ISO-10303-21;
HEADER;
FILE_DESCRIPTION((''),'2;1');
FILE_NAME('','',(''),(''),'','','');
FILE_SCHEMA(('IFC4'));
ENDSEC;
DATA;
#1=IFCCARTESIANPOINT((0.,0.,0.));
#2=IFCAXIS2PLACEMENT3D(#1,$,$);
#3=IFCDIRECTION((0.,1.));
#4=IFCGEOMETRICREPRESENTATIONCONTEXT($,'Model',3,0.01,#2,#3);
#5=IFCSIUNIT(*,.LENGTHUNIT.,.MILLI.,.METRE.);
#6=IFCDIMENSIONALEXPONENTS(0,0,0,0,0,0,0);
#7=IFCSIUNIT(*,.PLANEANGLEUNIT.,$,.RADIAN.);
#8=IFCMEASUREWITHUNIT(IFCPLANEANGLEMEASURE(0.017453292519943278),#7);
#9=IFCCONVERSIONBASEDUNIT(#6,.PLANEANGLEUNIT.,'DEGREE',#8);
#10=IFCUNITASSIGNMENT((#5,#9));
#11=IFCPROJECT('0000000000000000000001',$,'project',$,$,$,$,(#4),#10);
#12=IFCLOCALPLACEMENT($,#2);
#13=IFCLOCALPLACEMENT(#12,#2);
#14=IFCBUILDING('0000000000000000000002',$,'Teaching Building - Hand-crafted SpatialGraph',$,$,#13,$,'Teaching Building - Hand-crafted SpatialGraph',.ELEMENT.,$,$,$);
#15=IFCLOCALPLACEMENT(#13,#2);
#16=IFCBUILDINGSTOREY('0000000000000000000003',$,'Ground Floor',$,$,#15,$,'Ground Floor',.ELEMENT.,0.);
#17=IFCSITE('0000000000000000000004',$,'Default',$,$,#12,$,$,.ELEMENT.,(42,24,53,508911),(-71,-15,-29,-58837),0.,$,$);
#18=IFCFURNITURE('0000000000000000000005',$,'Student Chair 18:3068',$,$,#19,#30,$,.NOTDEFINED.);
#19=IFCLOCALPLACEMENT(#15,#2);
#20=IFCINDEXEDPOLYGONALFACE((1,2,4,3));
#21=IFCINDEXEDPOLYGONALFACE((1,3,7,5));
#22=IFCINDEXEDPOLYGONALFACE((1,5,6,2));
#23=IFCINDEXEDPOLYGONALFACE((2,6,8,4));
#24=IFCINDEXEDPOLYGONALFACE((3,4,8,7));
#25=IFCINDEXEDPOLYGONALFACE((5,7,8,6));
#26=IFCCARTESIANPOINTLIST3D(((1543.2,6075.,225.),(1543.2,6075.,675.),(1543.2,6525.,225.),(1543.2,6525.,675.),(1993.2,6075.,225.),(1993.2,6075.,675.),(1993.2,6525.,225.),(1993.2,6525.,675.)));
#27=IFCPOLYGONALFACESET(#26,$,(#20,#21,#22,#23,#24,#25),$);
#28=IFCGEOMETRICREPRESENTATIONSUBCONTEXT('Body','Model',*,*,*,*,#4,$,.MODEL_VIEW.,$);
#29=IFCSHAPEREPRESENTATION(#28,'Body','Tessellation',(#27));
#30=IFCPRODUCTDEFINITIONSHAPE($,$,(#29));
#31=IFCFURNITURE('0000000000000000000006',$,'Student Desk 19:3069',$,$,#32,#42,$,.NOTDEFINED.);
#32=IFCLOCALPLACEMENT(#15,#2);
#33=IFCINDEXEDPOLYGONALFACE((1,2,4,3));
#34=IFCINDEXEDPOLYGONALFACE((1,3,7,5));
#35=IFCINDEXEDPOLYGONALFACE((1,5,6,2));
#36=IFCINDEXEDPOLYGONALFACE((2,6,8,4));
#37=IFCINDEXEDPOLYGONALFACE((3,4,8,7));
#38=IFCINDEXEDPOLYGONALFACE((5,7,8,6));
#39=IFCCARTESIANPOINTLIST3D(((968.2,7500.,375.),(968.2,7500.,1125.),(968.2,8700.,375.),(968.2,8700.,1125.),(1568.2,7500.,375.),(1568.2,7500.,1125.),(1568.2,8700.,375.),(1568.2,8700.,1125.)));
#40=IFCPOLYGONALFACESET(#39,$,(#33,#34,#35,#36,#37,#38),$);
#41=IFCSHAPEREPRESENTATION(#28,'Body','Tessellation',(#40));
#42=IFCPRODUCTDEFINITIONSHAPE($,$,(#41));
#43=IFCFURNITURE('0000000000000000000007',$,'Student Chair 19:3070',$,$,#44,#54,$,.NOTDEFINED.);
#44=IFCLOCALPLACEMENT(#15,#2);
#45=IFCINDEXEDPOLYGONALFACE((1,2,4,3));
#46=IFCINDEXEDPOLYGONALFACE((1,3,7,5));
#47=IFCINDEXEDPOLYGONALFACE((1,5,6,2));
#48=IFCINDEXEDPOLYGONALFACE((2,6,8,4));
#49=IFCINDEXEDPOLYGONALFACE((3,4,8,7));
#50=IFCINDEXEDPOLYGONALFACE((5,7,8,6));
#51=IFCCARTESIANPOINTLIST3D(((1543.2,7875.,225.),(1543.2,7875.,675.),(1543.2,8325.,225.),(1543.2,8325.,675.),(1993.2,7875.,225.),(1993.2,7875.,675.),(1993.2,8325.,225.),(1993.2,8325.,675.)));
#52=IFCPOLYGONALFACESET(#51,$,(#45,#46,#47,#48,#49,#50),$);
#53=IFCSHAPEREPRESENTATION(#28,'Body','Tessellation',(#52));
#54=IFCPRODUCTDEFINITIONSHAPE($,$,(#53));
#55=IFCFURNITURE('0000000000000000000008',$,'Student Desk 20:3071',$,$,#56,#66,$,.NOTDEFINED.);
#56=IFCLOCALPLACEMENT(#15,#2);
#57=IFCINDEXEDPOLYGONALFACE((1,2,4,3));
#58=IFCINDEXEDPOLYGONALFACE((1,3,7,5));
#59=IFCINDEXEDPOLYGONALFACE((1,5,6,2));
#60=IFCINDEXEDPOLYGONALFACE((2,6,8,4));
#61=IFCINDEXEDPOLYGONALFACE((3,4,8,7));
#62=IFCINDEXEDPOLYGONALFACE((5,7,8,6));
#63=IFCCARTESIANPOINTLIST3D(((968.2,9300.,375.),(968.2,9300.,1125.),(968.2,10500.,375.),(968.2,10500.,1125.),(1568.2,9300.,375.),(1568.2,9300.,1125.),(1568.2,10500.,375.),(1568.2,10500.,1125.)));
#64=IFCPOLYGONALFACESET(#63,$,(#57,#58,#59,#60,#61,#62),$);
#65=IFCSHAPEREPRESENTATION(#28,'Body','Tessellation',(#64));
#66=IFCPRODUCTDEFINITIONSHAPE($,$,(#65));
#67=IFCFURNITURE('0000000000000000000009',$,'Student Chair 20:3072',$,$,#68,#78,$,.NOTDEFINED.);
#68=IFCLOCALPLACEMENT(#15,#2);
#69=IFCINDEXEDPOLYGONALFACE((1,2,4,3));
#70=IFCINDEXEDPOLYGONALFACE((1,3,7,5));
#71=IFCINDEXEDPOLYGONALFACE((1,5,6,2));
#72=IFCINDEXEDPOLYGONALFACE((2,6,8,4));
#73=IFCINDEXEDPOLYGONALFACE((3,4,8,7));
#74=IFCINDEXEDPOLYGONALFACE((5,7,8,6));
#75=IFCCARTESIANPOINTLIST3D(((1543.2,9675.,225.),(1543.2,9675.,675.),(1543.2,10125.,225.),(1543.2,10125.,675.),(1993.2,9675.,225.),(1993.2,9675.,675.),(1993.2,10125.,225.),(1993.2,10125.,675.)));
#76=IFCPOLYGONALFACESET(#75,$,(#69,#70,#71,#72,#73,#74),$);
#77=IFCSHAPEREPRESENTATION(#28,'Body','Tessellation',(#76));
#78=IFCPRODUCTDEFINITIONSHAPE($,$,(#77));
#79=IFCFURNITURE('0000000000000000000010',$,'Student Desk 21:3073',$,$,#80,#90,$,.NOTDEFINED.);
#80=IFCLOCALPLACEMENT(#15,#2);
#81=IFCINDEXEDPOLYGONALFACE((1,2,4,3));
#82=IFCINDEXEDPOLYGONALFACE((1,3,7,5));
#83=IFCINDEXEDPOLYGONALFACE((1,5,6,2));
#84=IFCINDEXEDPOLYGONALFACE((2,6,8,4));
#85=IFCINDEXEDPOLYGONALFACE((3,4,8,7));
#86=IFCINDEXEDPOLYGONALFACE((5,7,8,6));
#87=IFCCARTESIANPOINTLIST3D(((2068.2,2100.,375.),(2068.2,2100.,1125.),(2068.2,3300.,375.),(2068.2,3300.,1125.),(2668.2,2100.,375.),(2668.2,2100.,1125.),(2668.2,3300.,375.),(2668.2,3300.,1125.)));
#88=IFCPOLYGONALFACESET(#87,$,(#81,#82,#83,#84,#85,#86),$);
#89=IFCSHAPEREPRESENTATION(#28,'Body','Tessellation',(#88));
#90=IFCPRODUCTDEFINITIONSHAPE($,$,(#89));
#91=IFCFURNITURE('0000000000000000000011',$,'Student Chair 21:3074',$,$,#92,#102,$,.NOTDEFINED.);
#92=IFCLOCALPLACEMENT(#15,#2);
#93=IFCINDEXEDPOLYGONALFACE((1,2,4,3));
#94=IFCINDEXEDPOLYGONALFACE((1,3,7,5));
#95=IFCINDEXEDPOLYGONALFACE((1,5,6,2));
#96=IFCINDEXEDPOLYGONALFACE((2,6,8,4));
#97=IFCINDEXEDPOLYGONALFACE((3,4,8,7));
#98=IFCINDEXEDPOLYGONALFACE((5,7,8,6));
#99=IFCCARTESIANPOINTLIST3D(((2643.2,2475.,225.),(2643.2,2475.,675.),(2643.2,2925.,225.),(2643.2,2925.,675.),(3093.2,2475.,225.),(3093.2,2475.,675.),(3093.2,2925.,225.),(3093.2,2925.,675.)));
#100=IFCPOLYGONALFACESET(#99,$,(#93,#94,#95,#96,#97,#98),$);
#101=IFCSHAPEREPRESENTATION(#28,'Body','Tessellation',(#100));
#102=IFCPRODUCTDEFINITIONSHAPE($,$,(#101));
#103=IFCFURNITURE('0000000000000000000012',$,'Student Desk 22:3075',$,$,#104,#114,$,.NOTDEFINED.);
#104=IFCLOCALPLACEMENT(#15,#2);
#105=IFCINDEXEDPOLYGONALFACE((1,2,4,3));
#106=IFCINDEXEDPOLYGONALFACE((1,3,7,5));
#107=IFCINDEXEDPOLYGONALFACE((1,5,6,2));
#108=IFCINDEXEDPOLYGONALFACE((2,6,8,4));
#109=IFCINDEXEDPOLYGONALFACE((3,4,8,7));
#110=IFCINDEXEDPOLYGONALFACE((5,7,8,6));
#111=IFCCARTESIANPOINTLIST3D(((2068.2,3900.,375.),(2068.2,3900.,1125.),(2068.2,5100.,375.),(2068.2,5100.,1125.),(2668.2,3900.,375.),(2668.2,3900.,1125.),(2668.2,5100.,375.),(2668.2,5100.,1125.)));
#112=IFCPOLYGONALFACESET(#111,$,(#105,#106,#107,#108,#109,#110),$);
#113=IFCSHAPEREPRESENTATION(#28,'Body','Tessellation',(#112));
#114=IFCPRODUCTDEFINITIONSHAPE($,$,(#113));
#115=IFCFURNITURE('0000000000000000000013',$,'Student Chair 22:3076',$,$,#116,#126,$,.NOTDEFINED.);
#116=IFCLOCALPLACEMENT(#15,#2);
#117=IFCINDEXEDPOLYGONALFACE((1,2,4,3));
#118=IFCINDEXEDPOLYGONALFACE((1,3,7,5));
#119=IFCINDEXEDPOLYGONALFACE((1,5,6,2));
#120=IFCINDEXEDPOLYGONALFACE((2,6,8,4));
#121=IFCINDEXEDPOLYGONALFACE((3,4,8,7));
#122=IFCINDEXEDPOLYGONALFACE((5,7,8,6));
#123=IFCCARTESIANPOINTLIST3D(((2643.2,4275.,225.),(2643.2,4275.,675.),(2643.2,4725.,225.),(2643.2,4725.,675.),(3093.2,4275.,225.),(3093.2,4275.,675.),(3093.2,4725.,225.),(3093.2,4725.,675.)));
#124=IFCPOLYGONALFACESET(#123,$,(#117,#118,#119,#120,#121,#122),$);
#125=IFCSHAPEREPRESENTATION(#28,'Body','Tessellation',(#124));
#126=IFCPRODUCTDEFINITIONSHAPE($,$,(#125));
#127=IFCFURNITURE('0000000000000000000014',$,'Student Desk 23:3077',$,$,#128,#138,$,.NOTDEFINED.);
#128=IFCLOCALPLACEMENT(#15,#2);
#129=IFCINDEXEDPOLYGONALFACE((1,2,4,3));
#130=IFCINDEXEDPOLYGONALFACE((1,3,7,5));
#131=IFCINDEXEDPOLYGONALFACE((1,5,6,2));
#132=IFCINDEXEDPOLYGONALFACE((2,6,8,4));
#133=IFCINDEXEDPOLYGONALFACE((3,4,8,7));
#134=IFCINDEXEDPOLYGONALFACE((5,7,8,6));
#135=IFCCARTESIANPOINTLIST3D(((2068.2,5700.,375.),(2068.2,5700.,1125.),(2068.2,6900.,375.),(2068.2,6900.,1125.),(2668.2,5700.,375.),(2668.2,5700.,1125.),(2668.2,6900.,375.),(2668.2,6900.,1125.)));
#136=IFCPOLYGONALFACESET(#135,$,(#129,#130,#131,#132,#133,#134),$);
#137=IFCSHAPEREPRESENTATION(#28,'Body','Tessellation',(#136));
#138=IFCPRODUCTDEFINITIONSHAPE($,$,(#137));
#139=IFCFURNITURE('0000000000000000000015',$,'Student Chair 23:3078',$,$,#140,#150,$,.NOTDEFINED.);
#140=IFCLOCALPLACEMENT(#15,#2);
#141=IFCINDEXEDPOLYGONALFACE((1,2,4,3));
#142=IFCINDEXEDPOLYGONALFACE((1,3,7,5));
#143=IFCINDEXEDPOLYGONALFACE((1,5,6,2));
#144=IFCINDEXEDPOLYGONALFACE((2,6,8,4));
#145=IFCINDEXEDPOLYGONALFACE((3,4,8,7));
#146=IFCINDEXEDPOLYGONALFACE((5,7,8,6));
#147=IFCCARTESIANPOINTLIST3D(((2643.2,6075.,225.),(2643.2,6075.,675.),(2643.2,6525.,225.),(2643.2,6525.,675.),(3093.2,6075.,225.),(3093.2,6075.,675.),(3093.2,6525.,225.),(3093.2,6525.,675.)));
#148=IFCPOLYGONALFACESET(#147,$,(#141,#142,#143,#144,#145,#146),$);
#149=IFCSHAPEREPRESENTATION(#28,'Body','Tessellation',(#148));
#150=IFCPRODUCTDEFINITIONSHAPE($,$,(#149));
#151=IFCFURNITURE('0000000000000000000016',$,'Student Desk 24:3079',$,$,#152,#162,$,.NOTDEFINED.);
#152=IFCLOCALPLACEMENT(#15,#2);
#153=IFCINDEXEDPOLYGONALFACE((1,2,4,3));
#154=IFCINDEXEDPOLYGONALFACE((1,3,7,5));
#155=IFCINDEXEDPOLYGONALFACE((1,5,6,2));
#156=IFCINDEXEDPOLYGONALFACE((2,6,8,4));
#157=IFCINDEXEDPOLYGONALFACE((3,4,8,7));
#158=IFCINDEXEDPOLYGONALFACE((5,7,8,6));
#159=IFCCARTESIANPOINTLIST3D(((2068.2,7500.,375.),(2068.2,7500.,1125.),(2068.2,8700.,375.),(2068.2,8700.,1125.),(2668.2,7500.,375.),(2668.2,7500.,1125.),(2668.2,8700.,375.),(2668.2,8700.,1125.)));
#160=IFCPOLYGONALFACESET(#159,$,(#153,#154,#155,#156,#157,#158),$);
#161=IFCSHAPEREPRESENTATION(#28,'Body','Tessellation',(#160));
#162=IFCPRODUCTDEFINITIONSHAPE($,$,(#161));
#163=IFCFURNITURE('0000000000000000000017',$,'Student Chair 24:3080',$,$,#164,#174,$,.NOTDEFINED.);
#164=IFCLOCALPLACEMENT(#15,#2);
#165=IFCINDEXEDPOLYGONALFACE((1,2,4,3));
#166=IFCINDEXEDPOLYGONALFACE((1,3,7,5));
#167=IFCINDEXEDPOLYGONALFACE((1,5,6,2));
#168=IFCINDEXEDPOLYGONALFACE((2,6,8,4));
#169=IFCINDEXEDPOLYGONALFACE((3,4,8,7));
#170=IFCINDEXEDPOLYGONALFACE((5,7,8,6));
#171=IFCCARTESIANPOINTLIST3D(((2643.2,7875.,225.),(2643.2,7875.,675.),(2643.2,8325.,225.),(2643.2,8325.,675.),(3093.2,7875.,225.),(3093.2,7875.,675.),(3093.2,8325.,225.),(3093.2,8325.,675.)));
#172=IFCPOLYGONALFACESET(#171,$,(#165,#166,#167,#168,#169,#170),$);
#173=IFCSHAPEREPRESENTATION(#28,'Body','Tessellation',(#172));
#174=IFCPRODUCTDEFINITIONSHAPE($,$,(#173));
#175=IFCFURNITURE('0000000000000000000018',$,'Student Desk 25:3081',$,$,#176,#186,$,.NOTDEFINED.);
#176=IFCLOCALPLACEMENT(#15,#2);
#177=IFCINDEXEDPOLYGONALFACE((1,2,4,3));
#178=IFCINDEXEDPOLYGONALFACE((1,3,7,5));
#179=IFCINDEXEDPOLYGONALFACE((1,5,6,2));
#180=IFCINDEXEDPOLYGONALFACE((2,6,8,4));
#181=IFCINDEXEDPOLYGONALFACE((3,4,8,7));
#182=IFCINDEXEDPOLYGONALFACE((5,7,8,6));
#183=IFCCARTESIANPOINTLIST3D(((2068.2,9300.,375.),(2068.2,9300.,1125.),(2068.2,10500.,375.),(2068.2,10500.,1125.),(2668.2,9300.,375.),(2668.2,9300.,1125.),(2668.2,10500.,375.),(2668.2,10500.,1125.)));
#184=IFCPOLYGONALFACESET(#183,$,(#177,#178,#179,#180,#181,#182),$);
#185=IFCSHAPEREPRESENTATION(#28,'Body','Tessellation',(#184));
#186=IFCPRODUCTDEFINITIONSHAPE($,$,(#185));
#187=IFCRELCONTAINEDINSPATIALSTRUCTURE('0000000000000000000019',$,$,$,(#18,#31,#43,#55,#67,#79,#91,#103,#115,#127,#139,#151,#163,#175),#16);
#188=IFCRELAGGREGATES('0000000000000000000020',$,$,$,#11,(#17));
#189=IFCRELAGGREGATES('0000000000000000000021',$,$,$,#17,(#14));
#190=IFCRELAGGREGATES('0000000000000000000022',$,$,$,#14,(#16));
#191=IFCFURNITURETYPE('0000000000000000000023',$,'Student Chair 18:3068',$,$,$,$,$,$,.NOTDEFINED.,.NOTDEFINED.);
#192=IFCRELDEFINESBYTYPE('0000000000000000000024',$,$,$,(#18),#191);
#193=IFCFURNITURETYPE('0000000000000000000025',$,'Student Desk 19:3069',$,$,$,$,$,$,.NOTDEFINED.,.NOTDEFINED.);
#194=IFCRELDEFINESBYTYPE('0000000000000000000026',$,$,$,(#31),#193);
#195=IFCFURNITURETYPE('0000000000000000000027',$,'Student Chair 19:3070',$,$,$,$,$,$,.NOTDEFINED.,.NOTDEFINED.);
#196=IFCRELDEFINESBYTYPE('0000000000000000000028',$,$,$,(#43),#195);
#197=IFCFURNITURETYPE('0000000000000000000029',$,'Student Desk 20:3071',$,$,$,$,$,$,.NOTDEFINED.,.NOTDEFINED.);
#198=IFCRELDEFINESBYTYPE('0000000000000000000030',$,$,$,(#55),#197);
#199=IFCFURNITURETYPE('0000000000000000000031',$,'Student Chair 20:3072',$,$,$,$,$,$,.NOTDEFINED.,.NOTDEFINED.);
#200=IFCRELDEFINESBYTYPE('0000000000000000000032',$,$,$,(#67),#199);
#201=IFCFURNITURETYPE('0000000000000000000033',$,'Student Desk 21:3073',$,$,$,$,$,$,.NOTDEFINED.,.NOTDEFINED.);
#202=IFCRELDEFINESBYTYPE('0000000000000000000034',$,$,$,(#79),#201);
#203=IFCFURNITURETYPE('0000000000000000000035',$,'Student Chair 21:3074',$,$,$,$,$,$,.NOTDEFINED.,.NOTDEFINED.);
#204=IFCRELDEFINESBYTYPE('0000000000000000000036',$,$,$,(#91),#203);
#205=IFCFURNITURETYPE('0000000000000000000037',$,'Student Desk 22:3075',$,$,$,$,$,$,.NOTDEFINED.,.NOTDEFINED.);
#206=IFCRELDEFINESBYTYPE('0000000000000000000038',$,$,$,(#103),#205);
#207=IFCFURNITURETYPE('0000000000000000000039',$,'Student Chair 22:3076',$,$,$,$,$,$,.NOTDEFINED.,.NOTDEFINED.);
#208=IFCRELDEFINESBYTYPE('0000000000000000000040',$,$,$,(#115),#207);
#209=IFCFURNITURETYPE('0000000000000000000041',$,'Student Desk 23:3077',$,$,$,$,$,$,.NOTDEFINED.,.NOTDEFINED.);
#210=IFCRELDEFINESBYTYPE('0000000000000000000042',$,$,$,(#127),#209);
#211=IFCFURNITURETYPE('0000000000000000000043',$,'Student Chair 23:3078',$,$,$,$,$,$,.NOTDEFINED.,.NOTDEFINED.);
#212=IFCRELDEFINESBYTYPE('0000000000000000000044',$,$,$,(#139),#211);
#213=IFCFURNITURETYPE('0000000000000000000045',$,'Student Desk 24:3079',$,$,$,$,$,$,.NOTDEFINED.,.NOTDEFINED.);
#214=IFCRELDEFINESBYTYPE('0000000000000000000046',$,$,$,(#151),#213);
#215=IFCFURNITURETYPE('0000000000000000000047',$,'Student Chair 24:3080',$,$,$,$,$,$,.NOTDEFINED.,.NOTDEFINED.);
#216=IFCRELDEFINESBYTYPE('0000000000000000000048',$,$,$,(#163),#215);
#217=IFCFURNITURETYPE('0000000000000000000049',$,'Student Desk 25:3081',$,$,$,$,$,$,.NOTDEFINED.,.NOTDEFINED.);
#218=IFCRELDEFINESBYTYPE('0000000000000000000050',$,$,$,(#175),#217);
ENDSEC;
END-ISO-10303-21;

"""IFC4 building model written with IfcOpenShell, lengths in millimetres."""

from ifc_helpers import new_model, entity, si_unit, converted_unit, direction, frame, frame_2d, origin, origin_2d_with_axis, place, context, subcontext, project, spatial, rectangle, extrude, type_object, element, save


model = new_model("IFC4")

# Units and contexts
model_context = context("Model", 3, precision=0.01, world=origin(), true_north=direction((0.0, 1.0)))
body_context = subcontext(model_context, "Body", "Model", "MODEL_VIEW")
ifc_project = project(units=[si_unit("LENGTHUNIT", "METRE", prefix="MILLI"), converted_unit("PLANEANGLEUNIT", "DEGREE", entity("IfcPlaneAngleMeasure", 0.017453292519943278), si_unit("PLANEANGLEUNIT", "RADIAN"), dimensions=[0, 0, 0, 0, 0, 0, 0])], contexts=[model_context])

# Site, building, storey
site_placement = place(None, origin())
site = spatial("IfcSite", under=ifc_project, at=site_placement, Name="Default", CompositionType="ELEMENT", RefLatitude=(42, 24, 53, 508911), RefLongitude=(-71, -15, -29, -58837), RefElevation=0.0)
building_placement = place(site_placement, origin())
building = spatial("IfcBuilding", under=site, at=building_placement, Name="Teaching Building - Hand-crafted SpatialGraph", LongName="Teaching Building - Hand-crafted SpatialGraph", CompositionType="ELEMENT")
storey_placement = place(building_placement, origin())
storey = spatial("IfcBuildingStorey", under=building, at=storey_placement, Name="Ground Floor", LongName="Ground Floor", CompositionType="ELEMENT", Elevation=0.0)

# Furniture
furniture_type_1 = type_object("IfcFurnitureType", Name="Student Chair 18:3068", PredefinedType="NOTDEFINED")
furniture_1_placement = place(storey_placement, origin())
element("IfcFurniture", 1, at=furniture_1_placement, inside=storey, type_object=furniture_type_1, Name="Student Chair 18:3068", PredefinedType="NOTDEFINED", context=body_context, shape_type="SweptSolid", body=[
    extrude(rectangle(XDim=450.0, YDim=450.0, at=origin_2d_with_axis()), frame((1768.2, 6300.0, 225.0)), (0.0, 0.0, 1.0), 450.0),
])
furniture_type_2 = type_object("IfcFurnitureType", Name="Student Desk 19:3069", PredefinedType="NOTDEFINED")
furniture_2_placement = place(storey_placement, origin())
element("IfcFurniture", 2, at=furniture_2_placement, inside=storey, type_object=furniture_type_2, Name="Student Desk 19:3069", PredefinedType="NOTDEFINED", context=body_context, shape_type="SweptSolid", body=[
    extrude(rectangle(XDim=1200.0, YDim=600.0, at=origin_2d_with_axis()), frame((1268.2, 8100.0, 375.0), z_axis=(0.0, 0.0, 1.0), x_axis=(0.0, 1.0, 0.0)), (0.0, 0.0, 1.0), 750.0),
])
furniture_type_3 = type_object("IfcFurnitureType", Name="Student Chair 19:3070", PredefinedType="NOTDEFINED")
furniture_3_placement = place(storey_placement, origin())
element("IfcFurniture", 3, at=furniture_3_placement, inside=storey, type_object=furniture_type_3, Name="Student Chair 19:3070", PredefinedType="NOTDEFINED", context=body_context, shape_type="SweptSolid", body=[
    extrude(rectangle(XDim=450.0, YDim=450.0, at=origin_2d_with_axis()), frame((1768.2, 8100.0, 225.0)), (0.0, 0.0, 1.0), 450.0),
])
furniture_type_4 = type_object("IfcFurnitureType", Name="Student Desk 20:3071", PredefinedType="NOTDEFINED")
furniture_4_placement = place(storey_placement, origin())
element("IfcFurniture", 4, at=furniture_4_placement, inside=storey, type_object=furniture_type_4, Name="Student Desk 20:3071", PredefinedType="NOTDEFINED", context=body_context, shape_type="SweptSolid", body=[
    extrude(rectangle(XDim=1200.0, YDim=600.0, at=origin_2d_with_axis()), frame((1268.2, 9900.0, 375.0), z_axis=(0.0, 0.0, 1.0), x_axis=(0.0, 1.0, 0.0)), (0.0, 0.0, 1.0), 750.0),
])
furniture_type_5 = type_object("IfcFurnitureType", Name="Student Chair 20:3072", PredefinedType="NOTDEFINED")
furniture_5_placement = place(storey_placement, origin())
element("IfcFurniture", 5, at=furniture_5_placement, inside=storey, type_object=furniture_type_5, Name="Student Chair 20:3072", PredefinedType="NOTDEFINED", context=body_context, shape_type="SweptSolid", body=[
    extrude(rectangle(XDim=450.0, YDim=450.0, at=frame_2d((0.0, 0.0), x_axis=(1.0, 0.0))), frame((1768.2, 9900.0, 225.0)), (0.0, 0.0, 1.0), 450.0),
])
furniture_type_6 = type_object("IfcFurnitureType", Name="Student Desk 21:3073", PredefinedType="NOTDEFINED")
furniture_6_placement = place(storey_placement, origin())
element("IfcFurniture", 6, at=furniture_6_placement, inside=storey, type_object=furniture_type_6, Name="Student Desk 21:3073", PredefinedType="NOTDEFINED", context=body_context, shape_type="SweptSolid", body=[
    extrude(rectangle(XDim=1200.0, YDim=600.0, at=origin_2d_with_axis()), frame((2368.2, 2700.0, 375.0), z_axis=(0.0, 0.0, 1.0), x_axis=(0.0, 1.0, 0.0)), (0.0, 0.0, 1.0), 750.0),
])
furniture_type_7 = type_object("IfcFurnitureType", Name="Student Chair 21:3074", PredefinedType="NOTDEFINED")
furniture_7_placement = place(storey_placement, origin())
element("IfcFurniture", 7, at=furniture_7_placement, inside=storey, type_object=furniture_type_7, Name="Student Chair 21:3074", PredefinedType="NOTDEFINED", context=body_context, shape_type="SweptSolid", body=[
    extrude(rectangle(XDim=450.0, YDim=450.0, at=origin_2d_with_axis()), frame((2868.2, 2700.0, 225.0)), (0.0, 0.0, 1.0), 450.0),
])
furniture_type_8 = type_object("IfcFurnitureType", Name="Student Desk 22:3075", PredefinedType="NOTDEFINED")
furniture_8_placement = place(storey_placement, origin())
element("IfcFurniture", 8, at=furniture_8_placement, inside=storey, type_object=furniture_type_8, Name="Student Desk 22:3075", PredefinedType="NOTDEFINED", context=body_context, shape_type="SweptSolid", body=[
    extrude(rectangle(XDim=1200.0, YDim=600.0, at=frame_2d((0.0, 0.0), x_axis=(1.0, 0.0))), frame((2368.2, 4500.0, 375.0), z_axis=(0.0, 0.0, 1.0), x_axis=(0.0, 1.0, 0.0)), (0.0, 0.0, 1.0), 750.0),
])
furniture_type_9 = type_object("IfcFurnitureType", Name="Student Chair 22:3076", PredefinedType="NOTDEFINED")
furniture_9_placement = place(storey_placement, origin())
element("IfcFurniture", 9, at=furniture_9_placement, inside=storey, type_object=furniture_type_9, Name="Student Chair 22:3076", PredefinedType="NOTDEFINED", context=body_context, shape_type="SweptSolid", body=[
    extrude(rectangle(XDim=450.0, YDim=450.0, at=origin_2d_with_axis()), frame((2868.2, 4500.0, 225.0)), (0.0, 0.0, 1.0), 450.0),
])
furniture_type_10 = type_object("IfcFurnitureType", Name="Student Desk 23:3077", PredefinedType="NOTDEFINED")
furniture_10_placement = place(storey_placement, origin())
element("IfcFurniture", 10, at=furniture_10_placement, inside=storey, type_object=furniture_type_10, Name="Student Desk 23:3077", PredefinedType="NOTDEFINED", context=body_context, shape_type="SweptSolid", body=[
    extrude(rectangle(XDim=1200.0, YDim=600.0, at=origin_2d_with_axis()), frame((2368.2, 6300.0, 375.0), z_axis=(0.0, 0.0, 1.0), x_axis=(0.0, 1.0, 0.0)), (0.0, 0.0, 1.0), 750.0),
])
furniture_type_11 = type_object("IfcFurnitureType", Name="Student Chair 23:3078", PredefinedType="NOTDEFINED")
furniture_11_placement = place(storey_placement, origin())
element("IfcFurniture", 11, at=furniture_11_placement, inside=storey, type_object=furniture_type_11, Name="Student Chair 23:3078", PredefinedType="NOTDEFINED", context=body_context, shape_type="SweptSolid", body=[
    extrude(rectangle(XDim=450.0, YDim=450.0, at=origin_2d_with_axis()), frame((2868.2, 6300.0, 225.0)), (0.0, 0.0, 1.0), 450.0),
])
furniture_type_12 = type_object("IfcFurnitureType", Name="Student Desk 24:3079", PredefinedType="NOTDEFINED")
furniture_12_placement = place(storey_placement, origin())
element("IfcFurniture", 12, at=furniture_12_placement, inside=storey, type_object=furniture_type_12, Name="Student Desk 24:3079", PredefinedType="NOTDEFINED", context=body_context, shape_type="SweptSolid", body=[
    extrude(rectangle(XDim=1200.0, YDim=600.0, at=origin_2d_with_axis()), frame((2368.2, 8100.0, 375.0), z_axis=(0.0, 0.0, 1.0), x_axis=(0.0, 1.0, 0.0)), (0.0, 0.0, 1.0), 750.0),
])
furniture_type_13 = type_object("IfcFurnitureType", Name="Student Chair 24:3080", PredefinedType="NOTDEFINED")
furniture_13_placement = place(storey_placement, origin())
element("IfcFurniture", 13, at=furniture_13_placement, inside=storey, type_object=furniture_type_13, Name="Student Chair 24:3080", PredefinedType="NOTDEFINED", context=body_context, shape_type="SweptSolid", body=[
    extrude(rectangle(XDim=450.0, YDim=450.0, at=origin_2d_with_axis()), frame((2868.2, 8100.0, 225.0)), (0.0, 0.0, 1.0), 450.0),
])
furniture_type_14 = type_object("IfcFurnitureType", Name="Student Desk 25:3081", PredefinedType="NOTDEFINED")
furniture_14_placement = place(storey_placement, origin())
element("IfcFurniture", 14, at=furniture_14_placement, inside=storey, type_object=furniture_type_14, Name="Student Desk 25:3081", PredefinedType="NOTDEFINED", context=body_context, shape_type="SweptSolid", body=[
    extrude(rectangle(XDim=1200.0, YDim=600.0, at=origin_2d_with_axis()), frame((2368.2, 9900.0, 375.0), z_axis=(0.0, 0.0, 1.0), x_axis=(0.0, 1.0, 0.0)), (0.0, 0.0, 1.0), 750.0),
])

save(model, "model.ifc")
